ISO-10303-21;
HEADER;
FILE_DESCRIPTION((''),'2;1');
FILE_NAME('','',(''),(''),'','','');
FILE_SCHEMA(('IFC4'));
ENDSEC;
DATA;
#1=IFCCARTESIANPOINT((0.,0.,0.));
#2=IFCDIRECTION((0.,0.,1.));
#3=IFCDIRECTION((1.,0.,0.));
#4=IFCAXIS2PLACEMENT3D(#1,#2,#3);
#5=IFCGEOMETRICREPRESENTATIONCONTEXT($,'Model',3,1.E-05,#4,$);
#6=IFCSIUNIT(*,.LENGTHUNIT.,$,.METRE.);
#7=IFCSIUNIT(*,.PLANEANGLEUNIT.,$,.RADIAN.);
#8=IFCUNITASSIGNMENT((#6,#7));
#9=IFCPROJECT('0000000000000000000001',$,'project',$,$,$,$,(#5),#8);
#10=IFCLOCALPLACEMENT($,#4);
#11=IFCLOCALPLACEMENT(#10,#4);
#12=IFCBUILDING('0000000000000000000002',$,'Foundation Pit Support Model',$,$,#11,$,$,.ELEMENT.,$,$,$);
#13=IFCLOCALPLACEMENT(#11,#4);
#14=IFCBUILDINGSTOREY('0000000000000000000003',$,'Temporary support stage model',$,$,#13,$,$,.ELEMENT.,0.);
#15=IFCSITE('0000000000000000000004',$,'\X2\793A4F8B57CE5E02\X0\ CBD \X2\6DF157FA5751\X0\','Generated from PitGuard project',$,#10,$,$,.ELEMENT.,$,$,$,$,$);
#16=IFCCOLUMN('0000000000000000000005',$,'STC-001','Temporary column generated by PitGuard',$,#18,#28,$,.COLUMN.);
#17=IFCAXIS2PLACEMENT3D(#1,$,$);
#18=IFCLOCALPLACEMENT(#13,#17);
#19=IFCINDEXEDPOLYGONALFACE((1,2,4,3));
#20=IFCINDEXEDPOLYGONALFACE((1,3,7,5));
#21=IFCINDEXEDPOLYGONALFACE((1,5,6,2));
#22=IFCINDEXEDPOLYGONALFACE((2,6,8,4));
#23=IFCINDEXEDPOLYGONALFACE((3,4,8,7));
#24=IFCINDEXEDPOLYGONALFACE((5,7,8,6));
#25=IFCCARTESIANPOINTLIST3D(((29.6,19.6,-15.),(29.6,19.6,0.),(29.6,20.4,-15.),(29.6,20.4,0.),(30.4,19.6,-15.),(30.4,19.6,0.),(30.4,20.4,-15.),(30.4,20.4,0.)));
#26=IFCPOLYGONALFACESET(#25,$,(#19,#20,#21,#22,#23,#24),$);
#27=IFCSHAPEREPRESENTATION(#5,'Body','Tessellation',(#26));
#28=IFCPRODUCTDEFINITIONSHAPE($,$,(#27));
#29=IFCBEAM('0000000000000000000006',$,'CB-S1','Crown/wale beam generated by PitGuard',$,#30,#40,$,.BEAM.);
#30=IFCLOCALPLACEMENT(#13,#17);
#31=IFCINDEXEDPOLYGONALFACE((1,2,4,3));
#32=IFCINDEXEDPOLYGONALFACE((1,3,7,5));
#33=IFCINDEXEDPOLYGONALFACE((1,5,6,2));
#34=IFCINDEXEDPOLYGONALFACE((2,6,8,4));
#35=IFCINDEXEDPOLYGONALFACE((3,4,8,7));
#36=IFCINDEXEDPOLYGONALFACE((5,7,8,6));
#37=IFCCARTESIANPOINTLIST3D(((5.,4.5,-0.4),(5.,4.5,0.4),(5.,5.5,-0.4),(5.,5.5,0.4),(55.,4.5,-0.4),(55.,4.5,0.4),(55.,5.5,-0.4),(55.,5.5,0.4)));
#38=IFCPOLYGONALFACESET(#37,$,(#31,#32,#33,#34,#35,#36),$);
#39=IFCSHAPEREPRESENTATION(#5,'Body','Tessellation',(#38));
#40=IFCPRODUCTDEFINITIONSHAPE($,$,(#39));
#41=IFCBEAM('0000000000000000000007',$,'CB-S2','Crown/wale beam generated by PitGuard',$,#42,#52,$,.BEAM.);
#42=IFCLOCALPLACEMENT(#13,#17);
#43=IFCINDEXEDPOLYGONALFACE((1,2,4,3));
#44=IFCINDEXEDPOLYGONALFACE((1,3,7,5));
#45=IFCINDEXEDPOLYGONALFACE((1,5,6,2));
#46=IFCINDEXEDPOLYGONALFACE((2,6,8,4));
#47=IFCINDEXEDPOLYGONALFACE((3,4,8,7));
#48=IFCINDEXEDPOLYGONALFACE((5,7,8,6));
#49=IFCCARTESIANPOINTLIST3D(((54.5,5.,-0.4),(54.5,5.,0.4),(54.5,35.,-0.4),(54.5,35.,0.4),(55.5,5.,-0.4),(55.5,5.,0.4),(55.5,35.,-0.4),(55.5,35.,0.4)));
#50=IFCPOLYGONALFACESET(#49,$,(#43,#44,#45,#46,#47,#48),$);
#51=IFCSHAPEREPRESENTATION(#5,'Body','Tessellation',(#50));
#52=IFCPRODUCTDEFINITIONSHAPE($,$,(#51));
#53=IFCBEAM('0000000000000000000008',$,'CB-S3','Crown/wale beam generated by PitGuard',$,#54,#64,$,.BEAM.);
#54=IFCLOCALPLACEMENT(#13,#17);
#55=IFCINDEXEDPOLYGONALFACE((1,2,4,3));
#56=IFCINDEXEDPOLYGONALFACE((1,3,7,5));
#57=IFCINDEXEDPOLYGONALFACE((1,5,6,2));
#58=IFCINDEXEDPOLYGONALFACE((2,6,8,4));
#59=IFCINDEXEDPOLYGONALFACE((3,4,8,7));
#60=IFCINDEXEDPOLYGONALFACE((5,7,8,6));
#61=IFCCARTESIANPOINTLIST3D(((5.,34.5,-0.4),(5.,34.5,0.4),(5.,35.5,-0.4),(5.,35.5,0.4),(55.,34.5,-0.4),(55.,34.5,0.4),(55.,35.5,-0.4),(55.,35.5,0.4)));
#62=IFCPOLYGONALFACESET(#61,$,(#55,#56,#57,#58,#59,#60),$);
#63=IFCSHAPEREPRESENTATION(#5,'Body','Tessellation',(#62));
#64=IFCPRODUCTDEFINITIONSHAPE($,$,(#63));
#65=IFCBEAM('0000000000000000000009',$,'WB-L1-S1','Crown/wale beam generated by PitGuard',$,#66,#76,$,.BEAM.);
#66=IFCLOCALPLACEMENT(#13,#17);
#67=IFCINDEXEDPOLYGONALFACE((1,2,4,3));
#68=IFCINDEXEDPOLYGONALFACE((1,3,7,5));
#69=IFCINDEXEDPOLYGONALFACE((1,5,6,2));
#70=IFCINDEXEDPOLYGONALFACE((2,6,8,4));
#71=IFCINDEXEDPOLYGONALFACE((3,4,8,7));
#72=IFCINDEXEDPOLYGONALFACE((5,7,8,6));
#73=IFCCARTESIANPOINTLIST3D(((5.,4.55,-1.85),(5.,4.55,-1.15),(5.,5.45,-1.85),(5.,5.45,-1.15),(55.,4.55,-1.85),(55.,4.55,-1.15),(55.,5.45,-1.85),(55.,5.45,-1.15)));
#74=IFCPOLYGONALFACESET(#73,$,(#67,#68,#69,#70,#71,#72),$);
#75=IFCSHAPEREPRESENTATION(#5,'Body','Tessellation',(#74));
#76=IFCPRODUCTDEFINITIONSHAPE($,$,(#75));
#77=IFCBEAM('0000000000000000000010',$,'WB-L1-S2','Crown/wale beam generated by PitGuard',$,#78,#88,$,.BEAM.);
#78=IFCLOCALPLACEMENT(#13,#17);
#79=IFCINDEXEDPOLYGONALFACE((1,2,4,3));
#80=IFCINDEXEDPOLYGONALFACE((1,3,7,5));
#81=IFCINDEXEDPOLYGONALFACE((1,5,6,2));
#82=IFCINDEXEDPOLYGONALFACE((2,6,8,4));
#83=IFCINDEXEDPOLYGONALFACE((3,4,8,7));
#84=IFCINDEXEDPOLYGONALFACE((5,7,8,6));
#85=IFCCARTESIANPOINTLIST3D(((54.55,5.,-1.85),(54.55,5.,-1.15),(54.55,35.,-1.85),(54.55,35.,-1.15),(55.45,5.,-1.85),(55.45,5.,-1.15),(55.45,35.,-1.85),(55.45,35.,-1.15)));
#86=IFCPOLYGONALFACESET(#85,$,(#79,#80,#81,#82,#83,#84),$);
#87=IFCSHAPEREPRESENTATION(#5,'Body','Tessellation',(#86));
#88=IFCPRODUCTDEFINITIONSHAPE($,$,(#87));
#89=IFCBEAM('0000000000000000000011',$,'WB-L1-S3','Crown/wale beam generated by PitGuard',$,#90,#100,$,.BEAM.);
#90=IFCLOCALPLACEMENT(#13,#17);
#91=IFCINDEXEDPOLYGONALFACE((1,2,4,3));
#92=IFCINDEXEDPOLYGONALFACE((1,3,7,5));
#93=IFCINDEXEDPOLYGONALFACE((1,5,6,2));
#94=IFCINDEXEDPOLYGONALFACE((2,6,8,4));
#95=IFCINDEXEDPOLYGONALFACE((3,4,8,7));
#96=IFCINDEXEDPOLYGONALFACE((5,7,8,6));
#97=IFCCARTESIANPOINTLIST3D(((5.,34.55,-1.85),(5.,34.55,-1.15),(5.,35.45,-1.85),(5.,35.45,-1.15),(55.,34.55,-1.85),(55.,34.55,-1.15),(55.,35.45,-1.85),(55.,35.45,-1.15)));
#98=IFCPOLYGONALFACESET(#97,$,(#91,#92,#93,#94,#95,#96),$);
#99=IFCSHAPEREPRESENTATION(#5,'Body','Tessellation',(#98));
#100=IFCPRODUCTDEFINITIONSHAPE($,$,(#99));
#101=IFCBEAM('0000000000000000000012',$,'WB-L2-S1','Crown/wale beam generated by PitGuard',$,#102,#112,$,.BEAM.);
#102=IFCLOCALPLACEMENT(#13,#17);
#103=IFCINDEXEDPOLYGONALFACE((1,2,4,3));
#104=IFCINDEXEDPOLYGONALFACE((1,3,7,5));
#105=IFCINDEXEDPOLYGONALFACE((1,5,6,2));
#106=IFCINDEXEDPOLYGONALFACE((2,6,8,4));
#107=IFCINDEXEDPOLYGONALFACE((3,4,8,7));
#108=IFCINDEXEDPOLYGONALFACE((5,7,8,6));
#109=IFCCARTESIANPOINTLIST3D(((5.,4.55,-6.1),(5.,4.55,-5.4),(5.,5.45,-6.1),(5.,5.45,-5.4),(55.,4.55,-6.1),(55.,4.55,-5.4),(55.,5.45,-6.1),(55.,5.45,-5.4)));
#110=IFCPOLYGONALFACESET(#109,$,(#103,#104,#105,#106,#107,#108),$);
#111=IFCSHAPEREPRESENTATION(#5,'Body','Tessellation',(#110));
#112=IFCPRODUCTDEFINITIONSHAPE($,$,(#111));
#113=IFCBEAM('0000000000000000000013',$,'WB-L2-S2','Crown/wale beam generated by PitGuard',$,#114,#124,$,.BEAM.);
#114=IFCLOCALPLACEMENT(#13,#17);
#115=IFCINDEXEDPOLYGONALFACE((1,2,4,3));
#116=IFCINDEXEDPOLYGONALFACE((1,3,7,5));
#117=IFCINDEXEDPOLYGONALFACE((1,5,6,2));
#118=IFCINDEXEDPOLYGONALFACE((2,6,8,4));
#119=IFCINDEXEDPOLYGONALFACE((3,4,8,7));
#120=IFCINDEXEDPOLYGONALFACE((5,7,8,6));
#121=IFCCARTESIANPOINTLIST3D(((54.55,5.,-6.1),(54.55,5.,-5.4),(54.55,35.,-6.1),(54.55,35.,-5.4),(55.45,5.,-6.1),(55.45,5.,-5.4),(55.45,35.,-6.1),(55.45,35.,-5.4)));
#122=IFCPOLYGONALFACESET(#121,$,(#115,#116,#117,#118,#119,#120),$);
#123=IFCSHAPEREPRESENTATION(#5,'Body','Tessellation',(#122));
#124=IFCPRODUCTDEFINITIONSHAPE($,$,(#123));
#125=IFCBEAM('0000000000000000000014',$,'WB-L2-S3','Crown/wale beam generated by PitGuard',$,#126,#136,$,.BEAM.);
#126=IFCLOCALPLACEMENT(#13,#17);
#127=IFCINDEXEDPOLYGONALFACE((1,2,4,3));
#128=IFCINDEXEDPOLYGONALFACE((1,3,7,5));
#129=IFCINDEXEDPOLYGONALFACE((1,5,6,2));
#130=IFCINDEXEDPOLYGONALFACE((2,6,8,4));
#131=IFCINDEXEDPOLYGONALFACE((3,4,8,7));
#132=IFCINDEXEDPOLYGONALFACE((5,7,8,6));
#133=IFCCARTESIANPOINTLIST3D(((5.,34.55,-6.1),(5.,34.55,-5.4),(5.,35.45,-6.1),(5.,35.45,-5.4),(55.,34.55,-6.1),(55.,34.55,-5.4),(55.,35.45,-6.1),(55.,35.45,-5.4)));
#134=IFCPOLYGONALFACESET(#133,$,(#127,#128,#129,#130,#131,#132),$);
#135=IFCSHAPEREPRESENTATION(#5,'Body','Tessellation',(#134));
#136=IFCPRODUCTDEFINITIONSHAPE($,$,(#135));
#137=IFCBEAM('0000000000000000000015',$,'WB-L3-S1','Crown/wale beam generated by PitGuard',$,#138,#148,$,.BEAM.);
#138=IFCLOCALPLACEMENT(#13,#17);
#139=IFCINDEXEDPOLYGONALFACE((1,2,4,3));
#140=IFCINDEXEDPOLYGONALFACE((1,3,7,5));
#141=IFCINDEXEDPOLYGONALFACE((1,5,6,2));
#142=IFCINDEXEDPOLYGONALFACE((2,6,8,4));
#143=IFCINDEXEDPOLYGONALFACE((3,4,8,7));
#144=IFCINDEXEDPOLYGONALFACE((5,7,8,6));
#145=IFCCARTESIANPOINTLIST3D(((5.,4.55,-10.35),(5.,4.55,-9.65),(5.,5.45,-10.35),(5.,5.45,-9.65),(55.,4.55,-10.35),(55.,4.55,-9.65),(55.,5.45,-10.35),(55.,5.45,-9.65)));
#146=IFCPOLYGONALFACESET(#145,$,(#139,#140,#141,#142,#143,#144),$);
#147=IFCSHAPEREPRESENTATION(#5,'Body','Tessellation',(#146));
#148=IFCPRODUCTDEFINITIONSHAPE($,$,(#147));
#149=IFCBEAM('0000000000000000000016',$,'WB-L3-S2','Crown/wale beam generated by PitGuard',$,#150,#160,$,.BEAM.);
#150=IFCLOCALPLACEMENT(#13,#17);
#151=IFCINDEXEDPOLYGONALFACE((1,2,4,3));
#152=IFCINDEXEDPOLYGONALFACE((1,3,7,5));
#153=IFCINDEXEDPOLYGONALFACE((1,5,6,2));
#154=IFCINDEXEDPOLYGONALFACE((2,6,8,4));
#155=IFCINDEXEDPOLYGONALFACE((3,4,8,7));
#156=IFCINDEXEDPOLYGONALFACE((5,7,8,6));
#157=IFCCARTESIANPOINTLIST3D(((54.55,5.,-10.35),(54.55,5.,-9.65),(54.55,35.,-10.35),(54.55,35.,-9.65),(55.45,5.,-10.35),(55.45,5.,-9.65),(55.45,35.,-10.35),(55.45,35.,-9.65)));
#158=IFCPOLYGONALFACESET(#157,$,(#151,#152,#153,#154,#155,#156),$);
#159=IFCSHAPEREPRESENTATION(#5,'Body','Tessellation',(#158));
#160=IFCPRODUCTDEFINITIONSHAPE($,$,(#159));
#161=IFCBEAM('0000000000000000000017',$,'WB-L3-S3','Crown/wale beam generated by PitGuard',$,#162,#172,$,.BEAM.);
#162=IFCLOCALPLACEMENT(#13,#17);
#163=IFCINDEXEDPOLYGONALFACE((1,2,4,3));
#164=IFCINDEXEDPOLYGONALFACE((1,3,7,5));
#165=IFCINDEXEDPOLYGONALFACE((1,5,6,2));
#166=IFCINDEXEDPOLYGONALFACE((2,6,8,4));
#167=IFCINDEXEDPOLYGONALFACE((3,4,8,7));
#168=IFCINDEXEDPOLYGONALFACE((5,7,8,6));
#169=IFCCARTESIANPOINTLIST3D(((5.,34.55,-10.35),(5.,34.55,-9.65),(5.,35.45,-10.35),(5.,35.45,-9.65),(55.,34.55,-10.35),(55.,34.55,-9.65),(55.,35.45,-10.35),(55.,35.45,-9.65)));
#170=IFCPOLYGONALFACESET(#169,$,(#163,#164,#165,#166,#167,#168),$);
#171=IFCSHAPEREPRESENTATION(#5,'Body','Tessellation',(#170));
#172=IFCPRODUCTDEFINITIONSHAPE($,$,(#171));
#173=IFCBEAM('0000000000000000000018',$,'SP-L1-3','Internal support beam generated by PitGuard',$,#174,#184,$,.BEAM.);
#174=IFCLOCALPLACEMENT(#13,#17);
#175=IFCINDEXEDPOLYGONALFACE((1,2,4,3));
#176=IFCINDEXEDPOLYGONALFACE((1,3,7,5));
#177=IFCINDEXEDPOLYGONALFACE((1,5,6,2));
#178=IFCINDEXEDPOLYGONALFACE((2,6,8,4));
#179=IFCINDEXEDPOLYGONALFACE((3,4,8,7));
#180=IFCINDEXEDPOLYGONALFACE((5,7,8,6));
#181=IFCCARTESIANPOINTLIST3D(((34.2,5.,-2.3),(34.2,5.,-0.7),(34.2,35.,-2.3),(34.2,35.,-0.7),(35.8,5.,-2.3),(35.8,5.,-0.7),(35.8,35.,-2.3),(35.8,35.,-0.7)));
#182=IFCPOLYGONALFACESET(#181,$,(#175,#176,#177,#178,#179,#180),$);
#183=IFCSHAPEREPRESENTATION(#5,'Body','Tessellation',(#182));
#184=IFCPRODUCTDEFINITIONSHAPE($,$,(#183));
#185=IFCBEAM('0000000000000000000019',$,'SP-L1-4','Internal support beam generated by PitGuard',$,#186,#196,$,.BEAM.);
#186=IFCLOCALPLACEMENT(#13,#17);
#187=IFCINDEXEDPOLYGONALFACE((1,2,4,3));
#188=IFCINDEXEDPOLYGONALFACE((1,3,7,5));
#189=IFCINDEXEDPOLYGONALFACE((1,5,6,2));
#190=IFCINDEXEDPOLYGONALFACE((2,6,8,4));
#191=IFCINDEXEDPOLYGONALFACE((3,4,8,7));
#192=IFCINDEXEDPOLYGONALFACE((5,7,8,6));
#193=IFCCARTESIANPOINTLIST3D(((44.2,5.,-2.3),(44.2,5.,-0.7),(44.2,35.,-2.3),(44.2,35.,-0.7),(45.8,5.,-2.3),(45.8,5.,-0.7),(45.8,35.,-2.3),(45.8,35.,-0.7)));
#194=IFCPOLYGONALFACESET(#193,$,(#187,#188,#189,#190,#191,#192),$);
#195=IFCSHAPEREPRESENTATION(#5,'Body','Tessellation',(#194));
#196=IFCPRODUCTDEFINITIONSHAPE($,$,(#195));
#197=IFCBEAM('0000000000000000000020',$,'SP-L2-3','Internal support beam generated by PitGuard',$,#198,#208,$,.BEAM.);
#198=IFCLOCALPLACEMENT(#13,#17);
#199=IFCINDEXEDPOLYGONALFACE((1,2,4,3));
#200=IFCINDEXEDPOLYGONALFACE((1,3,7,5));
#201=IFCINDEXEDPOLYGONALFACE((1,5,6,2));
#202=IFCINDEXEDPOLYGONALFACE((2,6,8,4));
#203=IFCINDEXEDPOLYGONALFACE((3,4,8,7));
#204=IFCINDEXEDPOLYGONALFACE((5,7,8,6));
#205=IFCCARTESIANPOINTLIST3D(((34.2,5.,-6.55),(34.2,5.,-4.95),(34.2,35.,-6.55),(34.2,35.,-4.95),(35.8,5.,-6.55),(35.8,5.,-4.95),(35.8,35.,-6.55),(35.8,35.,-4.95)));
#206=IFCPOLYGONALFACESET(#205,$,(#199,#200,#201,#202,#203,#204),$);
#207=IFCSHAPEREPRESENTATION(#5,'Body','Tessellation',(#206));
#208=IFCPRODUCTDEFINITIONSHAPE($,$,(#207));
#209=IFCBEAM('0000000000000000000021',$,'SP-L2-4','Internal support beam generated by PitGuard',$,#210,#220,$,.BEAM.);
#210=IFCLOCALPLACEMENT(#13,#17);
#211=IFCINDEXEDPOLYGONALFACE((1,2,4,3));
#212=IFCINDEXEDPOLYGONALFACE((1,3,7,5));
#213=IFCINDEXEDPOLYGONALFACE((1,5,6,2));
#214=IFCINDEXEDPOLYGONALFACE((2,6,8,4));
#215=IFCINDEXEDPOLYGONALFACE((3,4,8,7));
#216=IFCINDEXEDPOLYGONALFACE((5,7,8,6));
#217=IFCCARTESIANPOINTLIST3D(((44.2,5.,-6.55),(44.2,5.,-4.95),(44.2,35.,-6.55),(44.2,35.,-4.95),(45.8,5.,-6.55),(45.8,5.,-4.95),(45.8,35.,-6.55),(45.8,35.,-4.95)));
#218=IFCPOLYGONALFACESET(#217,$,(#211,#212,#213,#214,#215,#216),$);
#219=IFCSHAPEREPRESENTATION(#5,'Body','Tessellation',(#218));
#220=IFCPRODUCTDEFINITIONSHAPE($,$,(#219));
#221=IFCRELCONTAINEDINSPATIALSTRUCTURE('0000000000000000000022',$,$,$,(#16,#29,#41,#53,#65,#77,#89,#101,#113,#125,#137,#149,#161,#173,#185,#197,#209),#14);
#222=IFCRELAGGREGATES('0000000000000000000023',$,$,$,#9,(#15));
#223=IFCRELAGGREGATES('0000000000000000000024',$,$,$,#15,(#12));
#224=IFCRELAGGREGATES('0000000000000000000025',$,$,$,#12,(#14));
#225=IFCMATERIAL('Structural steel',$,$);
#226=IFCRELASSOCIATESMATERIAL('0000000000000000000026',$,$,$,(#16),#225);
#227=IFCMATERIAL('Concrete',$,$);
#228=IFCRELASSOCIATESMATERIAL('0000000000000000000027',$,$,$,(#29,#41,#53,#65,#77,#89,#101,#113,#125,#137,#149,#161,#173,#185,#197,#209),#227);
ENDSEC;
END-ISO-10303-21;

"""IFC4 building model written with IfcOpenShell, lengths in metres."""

from ifc_helpers import new_model, si_unit, frame, origin_with_axes, origin_2d, place, context, project, spatial, rectangle, extrude, material, element, save


model = new_model("IFC4")

# Units and contexts
model_context = context("Model", 3, precision=1e-05, world=origin_with_axes())
ifc_project = project(units=[si_unit("LENGTHUNIT", "METRE"), si_unit("PLANEANGLEUNIT", "RADIAN")], contexts=[model_context])

# Site, building, storey
site_placement = place(None, origin_with_axes())
site = spatial("IfcSite", under=ifc_project, at=site_placement, Name="示例城市 CBD 深基坑", Description="Generated from PitGuard project", CompositionType="ELEMENT")
building_placement = place(site_placement, origin_with_axes())
building = spatial("IfcBuilding", under=site, at=building_placement, Name="Foundation Pit Support Model", CompositionType="ELEMENT")
storey_placement = place(building_placement, origin_with_axes())
storey = spatial("IfcBuildingStorey", under=building, at=storey_placement, Name="Temporary support stage model", CompositionType="ELEMENT", Elevation=0.0)

# Column
ifc_material_1 = material(Name="Structural steel")
column_placement = place(storey_placement, frame((30.0, 20.0, -15.0), z_axis=(0.0, 0.0, 1.0), x_axis=(1.0, 0.0, 0.0)))
element("IfcColumn", 1, at=column_placement, inside=storey, material=ifc_material_1, Name="STC-001", Description="Temporary column generated by PitGuard", PredefinedType="COLUMN", context=model_context, shape_type="SweptSolid", body=[
    extrude(rectangle(XDim=0.8, YDim=0.8, at=origin_2d()), origin_with_axes(), (0.0, 0.0, 1.0), 15.0),
])

# Beams
ifc_material_2 = material(Name="Concrete")
beam_1_placement = place(storey_placement, frame((30.0, 5.0, -0.4), z_axis=(0.0, 0.0, 1.0), x_axis=(1.0, 0.0, 0.0)))
element("IfcBeam", 2, at=beam_1_placement, inside=storey, material=ifc_material_2, Name="CB-S1", Description="Crown/wale beam generated by PitGuard", PredefinedType="BEAM", context=model_context, shape_type="SweptSolid", body=[
    extrude(rectangle(XDim=50.0, YDim=1.0, at=origin_2d()), origin_with_axes(), (0.0, 0.0, 1.0), 0.8),
])
beam_2_placement = place(storey_placement, frame((55.0, 20.0, -0.4), z_axis=(0.0, 0.0, 1.0), x_axis=(0.0, 1.0, 0.0)))
element("IfcBeam", 3, at=beam_2_placement, inside=storey, material=ifc_material_2, Name="CB-S2", Description="Crown/wale beam generated by PitGuard", PredefinedType="BEAM", context=model_context, shape_type="SweptSolid", body=[
    extrude(rectangle(XDim=30.0, YDim=1.0, at=origin_2d()), origin_with_axes(), (0.0, 0.0, 1.0), 0.8),
])
beam_3_placement = place(storey_placement, frame((30.0, 35.0, -0.4), z_axis=(0.0, 0.0, 1.0), x_axis=(-1.0, 0.0, 0.0)))
element("IfcBeam", 4, at=beam_3_placement, inside=storey, material=ifc_material_2, Name="CB-S3", Description="Crown/wale beam generated by PitGuard", PredefinedType="BEAM", context=model_context, shape_type="SweptSolid", body=[
    extrude(rectangle(XDim=50.0, YDim=1.0, at=origin_2d()), origin_with_axes(), (0.0, 0.0, 1.0), 0.8),
])
beam_4_placement = place(storey_placement, frame((30.0, 5.0, -1.85), z_axis=(0.0, 0.0, 1.0), x_axis=(1.0, 0.0, 0.0)))
element("IfcBeam", 5, at=beam_4_placement, inside=storey, material=ifc_material_2, Name="WB-L1-S1", Description="Crown/wale beam generated by PitGuard", PredefinedType="BEAM", context=model_context, shape_type="SweptSolid", body=[
    extrude(rectangle(XDim=50.0, YDim=0.9, at=origin_2d()), origin_with_axes(), (0.0, 0.0, 1.0), 0.7),
])
beam_5_placement = place(storey_placement, frame((55.0, 20.0, -1.85), z_axis=(0.0, 0.0, 1.0), x_axis=(0.0, 1.0, 0.0)))
element("IfcBeam", 6, at=beam_5_placement, inside=storey, material=ifc_material_2, Name="WB-L1-S2", Description="Crown/wale beam generated by PitGuard", PredefinedType="BEAM", context=model_context, shape_type="SweptSolid", body=[
    extrude(rectangle(XDim=30.0, YDim=0.9, at=origin_2d()), origin_with_axes(), (0.0, 0.0, 1.0), 0.7),
])
for number, where, z_axis, x_axis, name in (
    (7, (30.0, 35.0, -1.85), (0.0, 0.0, 1.0), (-1.0, 0.0, 0.0), "WB-L1-S3"),
    (8, (30.0, 5.0, -6.1), (0.0, 0.0, 1.0), (1.0, 0.0, 0.0), "WB-L2-S1"),
):
    element("IfcBeam", number, at=place(storey_placement, frame(where, z_axis=z_axis, x_axis=x_axis)), inside=storey, material=ifc_material_2, Name=name, Description="Crown/wale beam generated by PitGuard", PredefinedType="BEAM", context=model_context, shape_type="SweptSolid", body=[
        extrude(rectangle(XDim=50.0, YDim=0.9, at=origin_2d()), origin_with_axes(), (0.0, 0.0, 1.0), 0.7),
    ])
beam_6_placement = place(storey_placement, frame((55.0, 20.0, -6.1), z_axis=(0.0, 0.0, 1.0), x_axis=(0.0, 1.0, 0.0)))
element("IfcBeam", 9, at=beam_6_placement, inside=storey, material=ifc_material_2, Name="WB-L2-S2", Description="Crown/wale beam generated by PitGuard", PredefinedType="BEAM", context=model_context, shape_type="SweptSolid", body=[
    extrude(rectangle(XDim=30.0, YDim=0.9, at=origin_2d()), origin_with_axes(), (0.0, 0.0, 1.0), 0.7),
])
for number, where, z_axis, x_axis, name in (
    (10, (30.0, 35.0, -6.1), (0.0, 0.0, 1.0), (-1.0, 0.0, 0.0), "WB-L2-S3"),
    (11, (30.0, 5.0, -10.35), (0.0, 0.0, 1.0), (1.0, 0.0, 0.0), "WB-L3-S1"),
):
    element("IfcBeam", number, at=place(storey_placement, frame(where, z_axis=z_axis, x_axis=x_axis)), inside=storey, material=ifc_material_2, Name=name, Description="Crown/wale beam generated by PitGuard", PredefinedType="BEAM", context=model_context, shape_type="SweptSolid", body=[
        extrude(rectangle(XDim=50.0, YDim=0.9, at=origin_2d()), origin_with_axes(), (0.0, 0.0, 1.0), 0.7),
    ])
beam_7_placement = place(storey_placement, frame((55.0, 20.0, -10.35), z_axis=(0.0, 0.0, 1.0), x_axis=(0.0, 1.0, 0.0)))
element("IfcBeam", 12, at=beam_7_placement, inside=storey, material=ifc_material_2, Name="WB-L3-S2", Description="Crown/wale beam generated by PitGuard", PredefinedType="BEAM", context=model_context, shape_type="SweptSolid", body=[
    extrude(rectangle(XDim=30.0, YDim=0.9, at=origin_2d()), origin_with_axes(), (0.0, 0.0, 1.0), 0.7),
])
beam_8_placement = place(storey_placement, frame((30.0, 35.0, -10.35), z_axis=(0.0, 0.0, 1.0), x_axis=(-1.0, 0.0, 0.0)))
element("IfcBeam", 13, at=beam_8_placement, inside=storey, material=ifc_material_2, Name="WB-L3-S3", Description="Crown/wale beam generated by PitGuard", PredefinedType="BEAM", context=model_context, shape_type="SweptSolid", body=[
    extrude(rectangle(XDim=50.0, YDim=0.9, at=origin_2d()), origin_with_axes(), (0.0, 0.0, 1.0), 0.7),
])
for number, where, z_axis, x_axis, name in (
    (14, (35.0, 20.0, -2.3), (0.0, 0.0, 1.0), (0.0, 1.0, 0.0), "SP-L1-3"),
    (15, (45.0, 20.0, -2.3), (0.0, 0.0, 1.0), (0.0, 1.0, 0.0), "SP-L1-4"),
    (16, (35.0, 20.0, -6.55), (0.0, 0.0, 1.0), (0.0, 1.0, 0.0), "SP-L2-3"),
    (17, (45.0, 20.0, -6.55), (0.0, 0.0, 1.0), (0.0, 1.0, 0.0), "SP-L2-4"),
):
    element("IfcBeam", number, at=place(storey_placement, frame(where, z_axis=z_axis, x_axis=x_axis)), inside=storey, material=ifc_material_2, Name=name, Description="Internal support beam generated by PitGuard", PredefinedType="BEAM", context=model_context, shape_type="SweptSolid", body=[
        extrude(rectangle(XDim=30.0, YDim=1.6, at=origin_2d()), origin_with_axes(), (0.0, 0.0, 1.0), 1.6),
    ])

save(model, "model.ifc")
